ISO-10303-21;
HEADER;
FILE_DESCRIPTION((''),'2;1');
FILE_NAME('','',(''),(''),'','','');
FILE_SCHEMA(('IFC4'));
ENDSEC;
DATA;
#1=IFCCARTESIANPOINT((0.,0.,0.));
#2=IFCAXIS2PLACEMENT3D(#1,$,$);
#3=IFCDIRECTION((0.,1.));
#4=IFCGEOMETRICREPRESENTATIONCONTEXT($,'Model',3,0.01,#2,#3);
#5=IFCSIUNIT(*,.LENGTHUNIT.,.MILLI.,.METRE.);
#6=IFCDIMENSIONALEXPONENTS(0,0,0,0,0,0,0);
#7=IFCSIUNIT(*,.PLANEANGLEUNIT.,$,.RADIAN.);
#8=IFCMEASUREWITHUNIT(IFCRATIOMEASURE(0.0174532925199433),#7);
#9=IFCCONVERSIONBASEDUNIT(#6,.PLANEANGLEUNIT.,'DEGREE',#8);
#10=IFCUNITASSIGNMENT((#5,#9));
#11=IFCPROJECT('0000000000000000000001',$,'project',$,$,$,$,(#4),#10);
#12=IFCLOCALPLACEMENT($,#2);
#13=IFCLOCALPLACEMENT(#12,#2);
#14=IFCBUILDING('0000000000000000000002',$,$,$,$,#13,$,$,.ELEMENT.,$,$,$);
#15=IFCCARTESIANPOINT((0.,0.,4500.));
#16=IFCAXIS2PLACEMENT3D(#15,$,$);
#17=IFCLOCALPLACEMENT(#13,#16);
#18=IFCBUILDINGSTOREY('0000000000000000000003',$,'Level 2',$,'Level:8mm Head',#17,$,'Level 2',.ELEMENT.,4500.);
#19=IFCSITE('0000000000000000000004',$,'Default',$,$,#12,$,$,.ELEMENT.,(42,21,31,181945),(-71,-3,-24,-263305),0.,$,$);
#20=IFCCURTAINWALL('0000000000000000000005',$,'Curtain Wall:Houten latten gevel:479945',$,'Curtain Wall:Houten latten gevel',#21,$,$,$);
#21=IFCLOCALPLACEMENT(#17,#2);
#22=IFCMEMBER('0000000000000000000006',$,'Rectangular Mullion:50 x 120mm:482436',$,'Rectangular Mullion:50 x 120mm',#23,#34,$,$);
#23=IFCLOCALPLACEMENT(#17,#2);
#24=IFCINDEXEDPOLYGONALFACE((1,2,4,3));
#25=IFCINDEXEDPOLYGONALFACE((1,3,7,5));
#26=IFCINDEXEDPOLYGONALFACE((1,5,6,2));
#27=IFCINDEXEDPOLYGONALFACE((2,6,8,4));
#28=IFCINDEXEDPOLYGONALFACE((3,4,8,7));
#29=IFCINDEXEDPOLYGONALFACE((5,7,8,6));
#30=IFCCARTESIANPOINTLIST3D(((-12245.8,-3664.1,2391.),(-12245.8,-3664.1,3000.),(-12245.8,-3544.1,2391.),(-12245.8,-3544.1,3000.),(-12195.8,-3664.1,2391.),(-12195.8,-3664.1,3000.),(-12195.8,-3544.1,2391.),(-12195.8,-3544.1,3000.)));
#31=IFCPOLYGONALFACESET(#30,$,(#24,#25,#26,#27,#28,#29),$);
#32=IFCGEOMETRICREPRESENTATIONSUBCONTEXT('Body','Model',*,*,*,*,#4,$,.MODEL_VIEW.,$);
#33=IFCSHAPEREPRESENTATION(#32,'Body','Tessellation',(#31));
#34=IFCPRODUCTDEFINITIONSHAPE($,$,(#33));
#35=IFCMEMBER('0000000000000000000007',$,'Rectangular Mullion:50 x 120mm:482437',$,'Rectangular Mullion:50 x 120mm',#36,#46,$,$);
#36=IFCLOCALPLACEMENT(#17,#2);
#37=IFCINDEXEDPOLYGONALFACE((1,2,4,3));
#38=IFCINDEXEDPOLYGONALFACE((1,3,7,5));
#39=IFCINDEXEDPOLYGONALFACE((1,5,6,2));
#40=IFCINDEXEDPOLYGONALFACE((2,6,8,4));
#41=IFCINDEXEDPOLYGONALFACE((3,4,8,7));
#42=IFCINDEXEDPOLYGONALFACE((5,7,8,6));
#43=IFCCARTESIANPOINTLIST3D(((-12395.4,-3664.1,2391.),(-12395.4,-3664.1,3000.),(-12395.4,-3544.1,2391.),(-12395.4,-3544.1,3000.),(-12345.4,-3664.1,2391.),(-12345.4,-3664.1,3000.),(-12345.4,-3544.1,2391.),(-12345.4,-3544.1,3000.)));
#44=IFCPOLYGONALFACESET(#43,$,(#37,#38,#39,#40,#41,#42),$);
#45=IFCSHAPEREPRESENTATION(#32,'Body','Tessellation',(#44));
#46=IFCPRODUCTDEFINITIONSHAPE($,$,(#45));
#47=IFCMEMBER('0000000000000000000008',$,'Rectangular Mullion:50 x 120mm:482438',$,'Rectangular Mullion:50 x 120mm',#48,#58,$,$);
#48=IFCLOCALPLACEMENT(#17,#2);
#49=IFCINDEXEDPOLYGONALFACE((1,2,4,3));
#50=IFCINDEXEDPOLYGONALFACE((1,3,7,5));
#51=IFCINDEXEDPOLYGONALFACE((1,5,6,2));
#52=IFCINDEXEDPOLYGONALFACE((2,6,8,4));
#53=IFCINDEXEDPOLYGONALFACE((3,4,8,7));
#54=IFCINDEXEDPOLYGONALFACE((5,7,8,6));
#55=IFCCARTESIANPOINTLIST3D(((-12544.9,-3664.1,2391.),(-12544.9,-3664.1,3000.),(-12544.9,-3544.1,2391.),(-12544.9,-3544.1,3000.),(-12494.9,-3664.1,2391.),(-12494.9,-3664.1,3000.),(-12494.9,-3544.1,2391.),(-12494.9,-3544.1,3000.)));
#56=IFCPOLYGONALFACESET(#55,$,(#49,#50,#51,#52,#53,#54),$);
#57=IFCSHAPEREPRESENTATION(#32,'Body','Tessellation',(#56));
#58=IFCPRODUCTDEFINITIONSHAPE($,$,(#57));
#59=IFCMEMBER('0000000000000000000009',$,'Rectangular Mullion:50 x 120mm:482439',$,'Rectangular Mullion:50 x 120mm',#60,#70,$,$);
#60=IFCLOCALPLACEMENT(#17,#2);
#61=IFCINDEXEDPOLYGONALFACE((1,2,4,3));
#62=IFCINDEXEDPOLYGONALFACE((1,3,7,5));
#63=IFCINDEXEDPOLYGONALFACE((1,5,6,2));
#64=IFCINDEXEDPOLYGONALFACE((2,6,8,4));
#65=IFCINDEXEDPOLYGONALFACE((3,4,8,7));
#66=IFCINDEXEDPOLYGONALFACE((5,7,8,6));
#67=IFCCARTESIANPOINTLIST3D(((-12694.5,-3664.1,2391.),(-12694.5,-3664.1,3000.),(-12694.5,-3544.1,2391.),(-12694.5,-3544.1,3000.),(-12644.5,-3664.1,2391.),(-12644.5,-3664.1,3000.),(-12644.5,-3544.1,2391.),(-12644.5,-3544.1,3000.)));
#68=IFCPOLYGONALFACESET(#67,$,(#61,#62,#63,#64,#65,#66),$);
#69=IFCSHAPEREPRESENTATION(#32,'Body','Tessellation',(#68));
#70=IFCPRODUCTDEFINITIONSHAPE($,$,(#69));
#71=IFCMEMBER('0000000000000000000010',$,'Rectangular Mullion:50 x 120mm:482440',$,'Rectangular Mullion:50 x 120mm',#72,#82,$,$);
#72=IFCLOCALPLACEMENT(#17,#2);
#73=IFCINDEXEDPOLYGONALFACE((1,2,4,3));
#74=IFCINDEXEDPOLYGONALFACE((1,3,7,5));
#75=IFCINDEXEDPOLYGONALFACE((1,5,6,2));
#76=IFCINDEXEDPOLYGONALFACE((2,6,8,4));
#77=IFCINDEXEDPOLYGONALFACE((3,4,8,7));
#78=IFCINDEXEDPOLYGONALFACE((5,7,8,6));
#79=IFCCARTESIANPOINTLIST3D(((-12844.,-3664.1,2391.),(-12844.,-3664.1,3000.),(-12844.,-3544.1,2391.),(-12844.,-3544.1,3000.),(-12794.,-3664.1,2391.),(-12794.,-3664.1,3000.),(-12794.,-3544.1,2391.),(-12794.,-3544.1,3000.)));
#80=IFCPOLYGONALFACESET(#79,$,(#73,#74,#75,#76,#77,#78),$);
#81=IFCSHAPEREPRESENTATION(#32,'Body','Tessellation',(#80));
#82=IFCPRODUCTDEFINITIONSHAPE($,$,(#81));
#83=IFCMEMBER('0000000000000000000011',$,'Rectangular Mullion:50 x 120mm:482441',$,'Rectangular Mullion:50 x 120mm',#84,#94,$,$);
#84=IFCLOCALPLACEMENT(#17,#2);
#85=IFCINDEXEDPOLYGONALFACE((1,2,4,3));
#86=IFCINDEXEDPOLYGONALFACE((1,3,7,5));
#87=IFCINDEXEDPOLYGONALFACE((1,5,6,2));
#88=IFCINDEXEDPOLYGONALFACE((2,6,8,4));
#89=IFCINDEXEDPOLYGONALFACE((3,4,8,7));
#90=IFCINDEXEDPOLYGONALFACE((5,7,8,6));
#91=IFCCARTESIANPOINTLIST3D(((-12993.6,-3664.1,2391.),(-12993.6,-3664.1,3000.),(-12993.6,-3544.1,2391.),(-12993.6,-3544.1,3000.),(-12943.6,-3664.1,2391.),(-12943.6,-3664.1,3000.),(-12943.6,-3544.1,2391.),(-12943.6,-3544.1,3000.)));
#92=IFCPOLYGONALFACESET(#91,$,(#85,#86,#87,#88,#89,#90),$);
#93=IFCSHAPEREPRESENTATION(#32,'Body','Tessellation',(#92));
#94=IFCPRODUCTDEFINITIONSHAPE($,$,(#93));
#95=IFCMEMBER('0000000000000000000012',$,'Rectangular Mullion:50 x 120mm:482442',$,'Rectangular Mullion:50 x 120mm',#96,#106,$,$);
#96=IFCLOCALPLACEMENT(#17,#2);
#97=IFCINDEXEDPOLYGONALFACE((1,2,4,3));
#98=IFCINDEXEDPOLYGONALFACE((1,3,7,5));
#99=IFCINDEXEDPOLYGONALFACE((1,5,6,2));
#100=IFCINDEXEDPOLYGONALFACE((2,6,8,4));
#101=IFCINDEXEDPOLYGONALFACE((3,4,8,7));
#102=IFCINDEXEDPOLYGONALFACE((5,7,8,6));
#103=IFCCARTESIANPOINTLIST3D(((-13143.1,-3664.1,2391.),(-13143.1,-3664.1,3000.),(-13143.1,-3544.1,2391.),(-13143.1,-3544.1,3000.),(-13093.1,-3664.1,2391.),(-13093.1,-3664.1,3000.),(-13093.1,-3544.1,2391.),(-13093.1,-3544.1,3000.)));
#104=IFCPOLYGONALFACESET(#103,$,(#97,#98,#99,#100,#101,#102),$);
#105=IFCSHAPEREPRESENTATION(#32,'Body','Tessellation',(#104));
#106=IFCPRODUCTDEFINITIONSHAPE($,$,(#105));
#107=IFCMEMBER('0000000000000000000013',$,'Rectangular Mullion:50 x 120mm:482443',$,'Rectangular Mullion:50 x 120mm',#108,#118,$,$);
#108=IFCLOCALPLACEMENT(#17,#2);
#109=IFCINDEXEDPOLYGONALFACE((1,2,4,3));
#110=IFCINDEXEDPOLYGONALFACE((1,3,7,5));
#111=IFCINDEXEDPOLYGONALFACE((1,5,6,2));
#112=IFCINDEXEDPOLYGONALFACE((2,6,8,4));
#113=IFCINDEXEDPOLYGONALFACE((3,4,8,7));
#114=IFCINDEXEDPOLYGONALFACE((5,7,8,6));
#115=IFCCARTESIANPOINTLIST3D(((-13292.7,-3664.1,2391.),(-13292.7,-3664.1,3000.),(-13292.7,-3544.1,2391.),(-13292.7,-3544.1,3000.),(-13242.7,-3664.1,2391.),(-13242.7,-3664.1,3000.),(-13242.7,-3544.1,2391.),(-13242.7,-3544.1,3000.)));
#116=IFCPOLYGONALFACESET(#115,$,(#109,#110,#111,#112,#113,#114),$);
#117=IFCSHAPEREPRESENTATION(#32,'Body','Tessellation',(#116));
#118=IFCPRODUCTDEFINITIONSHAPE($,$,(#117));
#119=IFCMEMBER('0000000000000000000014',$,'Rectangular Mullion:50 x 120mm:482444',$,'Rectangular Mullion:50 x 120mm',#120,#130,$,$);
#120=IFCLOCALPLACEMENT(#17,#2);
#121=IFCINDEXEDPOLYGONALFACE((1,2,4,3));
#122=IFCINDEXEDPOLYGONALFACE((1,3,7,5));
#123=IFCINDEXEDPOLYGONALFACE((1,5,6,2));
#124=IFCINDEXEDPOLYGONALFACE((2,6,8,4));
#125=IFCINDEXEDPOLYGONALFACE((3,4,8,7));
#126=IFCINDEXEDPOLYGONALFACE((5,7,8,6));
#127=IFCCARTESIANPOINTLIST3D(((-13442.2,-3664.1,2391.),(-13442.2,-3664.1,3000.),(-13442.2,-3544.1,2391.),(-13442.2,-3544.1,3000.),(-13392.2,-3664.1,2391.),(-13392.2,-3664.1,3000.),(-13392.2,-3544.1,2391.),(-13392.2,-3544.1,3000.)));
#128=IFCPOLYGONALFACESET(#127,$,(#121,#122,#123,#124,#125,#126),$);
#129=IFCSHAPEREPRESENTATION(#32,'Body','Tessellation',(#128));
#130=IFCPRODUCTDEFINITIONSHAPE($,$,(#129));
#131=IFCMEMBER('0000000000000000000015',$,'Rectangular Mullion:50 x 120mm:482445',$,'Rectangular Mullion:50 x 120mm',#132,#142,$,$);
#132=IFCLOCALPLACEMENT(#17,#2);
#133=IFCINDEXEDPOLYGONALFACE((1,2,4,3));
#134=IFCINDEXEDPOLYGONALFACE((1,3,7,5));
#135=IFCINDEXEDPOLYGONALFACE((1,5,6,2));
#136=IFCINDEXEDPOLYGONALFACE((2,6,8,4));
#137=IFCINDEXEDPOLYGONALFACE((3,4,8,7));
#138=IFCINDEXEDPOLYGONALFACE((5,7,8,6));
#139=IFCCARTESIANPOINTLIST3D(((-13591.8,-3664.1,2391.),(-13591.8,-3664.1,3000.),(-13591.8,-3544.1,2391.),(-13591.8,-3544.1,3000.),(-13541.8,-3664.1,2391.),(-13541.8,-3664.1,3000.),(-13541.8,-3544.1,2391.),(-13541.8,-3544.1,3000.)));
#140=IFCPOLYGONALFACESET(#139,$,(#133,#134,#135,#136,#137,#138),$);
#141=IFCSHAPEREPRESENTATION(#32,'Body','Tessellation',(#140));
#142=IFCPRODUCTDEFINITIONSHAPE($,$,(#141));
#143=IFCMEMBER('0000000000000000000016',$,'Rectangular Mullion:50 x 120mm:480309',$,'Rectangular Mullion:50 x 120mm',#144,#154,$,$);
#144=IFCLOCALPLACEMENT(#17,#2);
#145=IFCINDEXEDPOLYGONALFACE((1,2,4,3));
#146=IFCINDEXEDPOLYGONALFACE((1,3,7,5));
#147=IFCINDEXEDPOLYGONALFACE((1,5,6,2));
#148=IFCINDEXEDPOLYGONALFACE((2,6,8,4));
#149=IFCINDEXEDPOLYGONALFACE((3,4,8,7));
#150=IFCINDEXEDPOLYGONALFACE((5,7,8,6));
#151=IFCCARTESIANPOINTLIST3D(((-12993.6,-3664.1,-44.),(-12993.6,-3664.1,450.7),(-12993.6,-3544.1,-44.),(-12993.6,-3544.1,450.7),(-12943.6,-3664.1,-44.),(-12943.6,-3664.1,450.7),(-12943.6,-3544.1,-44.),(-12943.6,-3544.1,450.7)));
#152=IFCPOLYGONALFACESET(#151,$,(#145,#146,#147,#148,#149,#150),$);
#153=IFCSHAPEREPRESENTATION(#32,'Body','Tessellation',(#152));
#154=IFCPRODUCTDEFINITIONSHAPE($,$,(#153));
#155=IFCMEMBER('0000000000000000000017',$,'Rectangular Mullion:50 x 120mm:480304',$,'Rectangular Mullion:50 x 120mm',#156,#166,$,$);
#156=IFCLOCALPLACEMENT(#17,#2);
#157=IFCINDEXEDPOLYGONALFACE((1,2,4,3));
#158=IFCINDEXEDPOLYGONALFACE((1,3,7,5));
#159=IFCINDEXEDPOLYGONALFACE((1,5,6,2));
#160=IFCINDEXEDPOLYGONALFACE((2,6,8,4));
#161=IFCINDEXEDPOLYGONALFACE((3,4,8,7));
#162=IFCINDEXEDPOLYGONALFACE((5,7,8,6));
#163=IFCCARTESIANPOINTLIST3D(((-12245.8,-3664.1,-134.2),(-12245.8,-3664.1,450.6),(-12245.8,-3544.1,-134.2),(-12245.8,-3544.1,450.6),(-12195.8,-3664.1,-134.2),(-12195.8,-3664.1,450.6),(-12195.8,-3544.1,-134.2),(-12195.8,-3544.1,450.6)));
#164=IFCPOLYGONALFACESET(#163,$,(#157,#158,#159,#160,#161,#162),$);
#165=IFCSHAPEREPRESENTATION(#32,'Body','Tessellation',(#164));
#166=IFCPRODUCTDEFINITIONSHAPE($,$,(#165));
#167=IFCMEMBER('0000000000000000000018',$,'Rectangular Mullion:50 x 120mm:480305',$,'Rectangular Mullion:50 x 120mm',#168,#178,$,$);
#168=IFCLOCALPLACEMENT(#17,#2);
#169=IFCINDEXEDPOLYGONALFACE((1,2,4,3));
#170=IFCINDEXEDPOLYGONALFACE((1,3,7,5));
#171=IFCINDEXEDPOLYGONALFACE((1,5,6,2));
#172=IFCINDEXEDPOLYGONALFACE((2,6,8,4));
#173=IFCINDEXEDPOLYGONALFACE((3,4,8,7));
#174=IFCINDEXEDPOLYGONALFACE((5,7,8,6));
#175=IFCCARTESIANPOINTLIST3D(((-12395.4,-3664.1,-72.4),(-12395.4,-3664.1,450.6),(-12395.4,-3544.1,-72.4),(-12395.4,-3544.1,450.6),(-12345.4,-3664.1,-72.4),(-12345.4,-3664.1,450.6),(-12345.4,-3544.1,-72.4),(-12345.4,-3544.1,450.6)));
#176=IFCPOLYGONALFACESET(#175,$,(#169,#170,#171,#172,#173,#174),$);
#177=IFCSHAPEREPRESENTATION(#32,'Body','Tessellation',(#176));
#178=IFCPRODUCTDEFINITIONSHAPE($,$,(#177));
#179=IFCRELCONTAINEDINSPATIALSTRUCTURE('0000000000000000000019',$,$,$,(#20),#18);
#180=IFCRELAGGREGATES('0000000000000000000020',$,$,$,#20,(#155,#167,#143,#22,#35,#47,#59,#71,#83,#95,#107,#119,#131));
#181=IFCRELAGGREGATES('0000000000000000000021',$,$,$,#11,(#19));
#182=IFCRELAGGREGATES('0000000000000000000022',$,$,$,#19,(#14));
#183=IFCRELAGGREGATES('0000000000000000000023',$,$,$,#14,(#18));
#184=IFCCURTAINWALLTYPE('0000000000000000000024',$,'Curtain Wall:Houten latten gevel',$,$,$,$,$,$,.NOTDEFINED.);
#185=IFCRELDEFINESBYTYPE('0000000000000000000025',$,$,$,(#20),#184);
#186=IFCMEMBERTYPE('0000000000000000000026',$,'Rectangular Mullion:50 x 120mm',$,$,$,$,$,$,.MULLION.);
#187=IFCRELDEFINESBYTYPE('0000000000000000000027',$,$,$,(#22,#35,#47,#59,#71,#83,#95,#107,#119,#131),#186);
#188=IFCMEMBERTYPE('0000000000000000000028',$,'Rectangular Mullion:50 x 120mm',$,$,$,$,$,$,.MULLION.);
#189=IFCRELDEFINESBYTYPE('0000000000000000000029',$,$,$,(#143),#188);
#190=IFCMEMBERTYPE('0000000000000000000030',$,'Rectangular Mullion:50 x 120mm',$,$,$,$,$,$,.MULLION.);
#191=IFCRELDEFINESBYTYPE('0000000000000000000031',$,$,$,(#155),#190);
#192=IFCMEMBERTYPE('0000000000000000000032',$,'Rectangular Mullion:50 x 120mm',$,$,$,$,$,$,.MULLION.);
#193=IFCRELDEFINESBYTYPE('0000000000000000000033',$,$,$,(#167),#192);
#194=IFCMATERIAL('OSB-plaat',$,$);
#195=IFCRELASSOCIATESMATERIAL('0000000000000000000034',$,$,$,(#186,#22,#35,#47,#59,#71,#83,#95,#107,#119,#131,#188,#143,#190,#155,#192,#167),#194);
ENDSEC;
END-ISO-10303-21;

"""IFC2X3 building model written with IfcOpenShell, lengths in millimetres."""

from ifc_helpers import new_model, entity, si_unit, converted_unit, direction, frame, origin, origin_2d_with_axis, place, context, subcontext, project, spatial, rectangle, extrude, source, transform, mapped, material, type_object, type_shapes, element, aggregate, save


model = new_model("IFC2X3")

# Units and contexts
model_context = context("Model", 3, precision=0.01, world=origin(), true_north=direction((0.0, 1.0)))
body_context = subcontext(model_context, "Body", "Model", "MODEL_VIEW")
ifc_project = project(units=[si_unit("LENGTHUNIT", "METRE", prefix="MILLI"), converted_unit("PLANEANGLEUNIT", "DEGREE", entity("IfcRatioMeasure", 0.0174532925199433), si_unit("PLANEANGLEUNIT", "RADIAN"), dimensions=[0, 0, 0, 0, 0, 0, 0])], contexts=[model_context])

# Site, building, storey
site_placement = place(None, frame((0.0, 0.0, 0.0)))
site = spatial("IfcSite", under=ifc_project, at=site_placement, Name="Default", CompositionType="ELEMENT", RefLatitude=(42, 21, 31, 181945), RefLongitude=(-71, -3, -24, -263305), RefElevation=0.0)
building_placement = place(site_placement, origin())
building = spatial("IfcBuilding", under=site, at=building_placement, CompositionType="ELEMENT")
storey_placement = place(building_placement, frame((0.0, 0.0, 4500.0)))
storey = spatial("IfcBuildingStorey", under=building, at=storey_placement, Name="Level 2", ObjectType="Level:8mm Head", LongName="Level 2", CompositionType="ELEMENT", Elevation=4500.0)

# Curtain wall, members
curtain_wall_type = type_object("IfcCurtainWallType", Name="Curtain Wall:Houten latten gevel", PredefinedType="NOTDEFINED")
curtain_wall_placement = place(storey_placement, frame((0.0, 0.0, -4500.0)))
curtain_wall = element("IfcCurtainWall", 1, at=curtain_wall_placement, inside=storey, type_object=curtain_wall_type, Name="Curtain Wall:Houten latten gevel:479945", ObjectType="Curtain Wall:Houten latten gevel")
ifc_material_1 = material(Name="OSB-plaat")
member_type_1 = type_object("IfcMemberType", Name="Rectangular Mullion:50 x 120mm", PredefinedType="MULLION", material=ifc_material_1)
shared_shape_1 = source(origin(), body_context, "Body", "SweptSolid", [
    extrude(rectangle(XDim=120.0, YDim=50.0, at=origin_2d_with_axis()), frame((0.0, 0.0, -609.0), z_axis=(0.0, 0.0, 1.0), x_axis=(0.0, -1.0, 0.0)), (0.0, 0.0, 1.0), 609.0),
])
type_shapes(member_type_1, [shared_shape_1])
member_1_placement = place(storey_placement, frame((-12220.8, -3604.1, 2391.0), z_axis=(0.0, 0.0, -1.0), x_axis=(-1.0, 0.0, 0.0)))
member_1 = element("IfcMember", 2, at=member_1_placement, type_object=member_type_1, material=ifc_material_1, Name="Rectangular Mullion:50 x 120mm:482436", ObjectType="Rectangular Mullion:50 x 120mm", context=body_context, shape_type="MappedRepresentation", body=[
    mapped(shared_shape_1, transform((0.0, 0.0, 0.0), scale=1.0)),
])
member_2_placement = place(storey_placement, frame((-12370.4, -3604.1, 2391.0), z_axis=(0.0, 0.0, -1.0), x_axis=(-1.0, 0.0, 0.0)))
member_2 = element("IfcMember", 3, at=member_2_placement, type_object=member_type_1, material=ifc_material_1, Name="Rectangular Mullion:50 x 120mm:482437", ObjectType="Rectangular Mullion:50 x 120mm", context=body_context, shape_type="MappedRepresentation", body=[
    mapped(shared_shape_1, transform((0.0, 0.0, 0.0), scale=1.0)),
])
member_3_placement = place(storey_placement, frame((-12519.9, -3604.1, 2391.0), z_axis=(0.0, 0.0, -1.0), x_axis=(-1.0, 0.0, 0.0)))
member_3 = element("IfcMember", 4, at=member_3_placement, type_object=member_type_1, material=ifc_material_1, Name="Rectangular Mullion:50 x 120mm:482438", ObjectType="Rectangular Mullion:50 x 120mm", context=body_context, shape_type="MappedRepresentation", body=[
    mapped(shared_shape_1, transform((0.0, 0.0, 0.0), scale=1.0)),
])
member_4_placement = place(storey_placement, frame((-12669.5, -3604.1, 2391.0), z_axis=(0.0, 0.0, -1.0), x_axis=(-1.0, 0.0, 0.0)))
member_4 = element("IfcMember", 5, at=member_4_placement, type_object=member_type_1, material=ifc_material_1, Name="Rectangular Mullion:50 x 120mm:482439", ObjectType="Rectangular Mullion:50 x 120mm", context=body_context, shape_type="MappedRepresentation", body=[
    mapped(shared_shape_1, transform((0.0, 0.0, 0.0), scale=1.0)),
])
member_5_placement = place(storey_placement, frame((-12819.0, -3604.1, 2391.0), z_axis=(0.0, 0.0, -1.0), x_axis=(-1.0, 0.0, 0.0)))
member_5 = element("IfcMember", 6, at=member_5_placement, type_object=member_type_1, material=ifc_material_1, Name="Rectangular Mullion:50 x 120mm:482440", ObjectType="Rectangular Mullion:50 x 120mm", context=body_context, shape_type="MappedRepresentation", body=[
    mapped(shared_shape_1, transform((0.0, 0.0, 0.0), scale=1.0)),
])
member_6_placement = place(storey_placement, frame((-12968.6, -3604.1, 2391.0), z_axis=(0.0, 0.0, -1.0), x_axis=(-1.0, 0.0, 0.0)))
member_6 = element("IfcMember", 7, at=member_6_placement, type_object=member_type_1, material=ifc_material_1, Name="Rectangular Mullion:50 x 120mm:482441", ObjectType="Rectangular Mullion:50 x 120mm", context=body_context, shape_type="MappedRepresentation", body=[
    mapped(shared_shape_1, transform((0.0, 0.0, 0.0), scale=1.0)),
])
member_7_placement = place(storey_placement, frame((-13118.1, -3604.1, 2391.0), z_axis=(0.0, 0.0, -1.0), x_axis=(-1.0, 0.0, 0.0)))
member_7 = element("IfcMember", 8, at=member_7_placement, type_object=member_type_1, material=ifc_material_1, Name="Rectangular Mullion:50 x 120mm:482442", ObjectType="Rectangular Mullion:50 x 120mm", context=body_context, shape_type="MappedRepresentation", body=[
    mapped(shared_shape_1, transform((0.0, 0.0, 0.0), scale=1.0)),
])
member_8_placement = place(storey_placement, frame((-13267.7, -3604.1, 2391.0), z_axis=(0.0, 0.0, -1.0), x_axis=(-1.0, 0.0, 0.0)))
member_8 = element("IfcMember", 9, at=member_8_placement, type_object=member_type_1, material=ifc_material_1, Name="Rectangular Mullion:50 x 120mm:482443", ObjectType="Rectangular Mullion:50 x 120mm", context=body_context, shape_type="MappedRepresentation", body=[
    mapped(shared_shape_1, transform((0.0, 0.0, 0.0), scale=1.0)),
])
member_9_placement = place(storey_placement, frame((-13417.2, -3604.1, 2391.0), z_axis=(0.0, 0.0, -1.0), x_axis=(-1.0, 0.0, 0.0)))
member_9 = element("IfcMember", 10, at=member_9_placement, type_object=member_type_1, material=ifc_material_1, Name="Rectangular Mullion:50 x 120mm:482444", ObjectType="Rectangular Mullion:50 x 120mm", context=body_context, shape_type="MappedRepresentation", body=[
    mapped(shared_shape_1, transform((0.0, 0.0, 0.0), scale=1.0)),
])
member_10_placement = place(storey_placement, frame((-13566.8, -3604.1, 2391.0), z_axis=(0.0, 0.0, -1.0), x_axis=(-1.0, 0.0, 0.0)))
member_10 = element("IfcMember", 11, at=member_10_placement, type_object=member_type_1, material=ifc_material_1, Name="Rectangular Mullion:50 x 120mm:482445", ObjectType="Rectangular Mullion:50 x 120mm", context=body_context, shape_type="MappedRepresentation", body=[
    mapped(shared_shape_1, transform((0.0, 0.0, 0.0), scale=1.0)),
])
member_type_2 = type_object("IfcMemberType", Name="Rectangular Mullion:50 x 120mm", PredefinedType="MULLION", material=ifc_material_1)
shared_shape_2 = source(origin(), body_context, "Body", "SweptSolid", [
    extrude(rectangle(XDim=120.0, YDim=50.0, at=origin_2d_with_axis()), frame((0.0, 0.0, -494.7), z_axis=(0.0, 0.0, 1.0), x_axis=(0.0, -1.0, 0.0)), (0.0, 0.0, 1.0), 494.7),
])
type_shapes(member_type_2, [shared_shape_2])
member_11_placement = place(storey_placement, frame((-12968.6, -3604.1, -44.0), z_axis=(0.0, 0.0, -1.0), x_axis=(-1.0, 0.0, 0.0)))
member_11 = element("IfcMember", 12, at=member_11_placement, type_object=member_type_2, material=ifc_material_1, Name="Rectangular Mullion:50 x 120mm:480309", ObjectType="Rectangular Mullion:50 x 120mm", context=body_context, shape_type="MappedRepresentation", body=[
    mapped(shared_shape_2, transform((0.0, 0.0, 0.0), scale=1.0)),
])
member_type_3 = type_object("IfcMemberType", Name="Rectangular Mullion:50 x 120mm", PredefinedType="MULLION", material=ifc_material_1)
shared_shape_3 = source(origin(), body_context, "Body", "SweptSolid", [
    extrude(rectangle(XDim=120.0, YDim=50.0, at=origin_2d_with_axis()), frame((0.0, 0.0, -584.8), z_axis=(0.0, 0.0, 1.0), x_axis=(0.0, -1.0, 0.0)), (0.0, 0.0, 1.0), 584.8),
])
type_shapes(member_type_3, [shared_shape_3])
member_12_placement = place(storey_placement, frame((-12220.8, -3604.1, -134.2), z_axis=(0.0, 0.0, -1.0), x_axis=(-1.0, 0.0, 0.0)))
member_12 = element("IfcMember", 13, at=member_12_placement, type_object=member_type_3, material=ifc_material_1, Name="Rectangular Mullion:50 x 120mm:480304", ObjectType="Rectangular Mullion:50 x 120mm", context=body_context, shape_type="MappedRepresentation", body=[
    mapped(shared_shape_3, transform((0.0, 0.0, 0.0), scale=1.0)),
])
member_type_4 = type_object("IfcMemberType", Name="Rectangular Mullion:50 x 120mm", PredefinedType="MULLION", material=ifc_material_1)
shared_shape_4 = source(origin(), body_context, "Body", "SweptSolid", [
    extrude(rectangle(XDim=120.0, YDim=50.0, at=origin_2d_with_axis()), frame((0.0, 0.0, -523.0), z_axis=(0.0, 0.0, 1.0), x_axis=(0.0, -1.0, 0.0)), (0.0, 0.0, 1.0), 523.0),
])
type_shapes(member_type_4, [shared_shape_4])
member_13_placement = place(storey_placement, frame((-12370.4, -3604.1, -72.4), z_axis=(0.0, 0.0, -1.0), x_axis=(-1.0, 0.0, 0.0)))
member_13 = element("IfcMember", 14, at=member_13_placement, type_object=member_type_4, material=ifc_material_1, Name="Rectangular Mullion:50 x 120mm:480305", ObjectType="Rectangular Mullion:50 x 120mm", context=body_context, shape_type="MappedRepresentation", body=[
    mapped(shared_shape_4, transform((0.0, 0.0, 0.0), scale=1.0)),
])
aggregate(curtain_wall, [member_12, member_13, member_11, member_1, member_2, member_3, member_4, member_5, member_6, member_7, member_8, member_9, member_10])

save(model, "model.ifc")
